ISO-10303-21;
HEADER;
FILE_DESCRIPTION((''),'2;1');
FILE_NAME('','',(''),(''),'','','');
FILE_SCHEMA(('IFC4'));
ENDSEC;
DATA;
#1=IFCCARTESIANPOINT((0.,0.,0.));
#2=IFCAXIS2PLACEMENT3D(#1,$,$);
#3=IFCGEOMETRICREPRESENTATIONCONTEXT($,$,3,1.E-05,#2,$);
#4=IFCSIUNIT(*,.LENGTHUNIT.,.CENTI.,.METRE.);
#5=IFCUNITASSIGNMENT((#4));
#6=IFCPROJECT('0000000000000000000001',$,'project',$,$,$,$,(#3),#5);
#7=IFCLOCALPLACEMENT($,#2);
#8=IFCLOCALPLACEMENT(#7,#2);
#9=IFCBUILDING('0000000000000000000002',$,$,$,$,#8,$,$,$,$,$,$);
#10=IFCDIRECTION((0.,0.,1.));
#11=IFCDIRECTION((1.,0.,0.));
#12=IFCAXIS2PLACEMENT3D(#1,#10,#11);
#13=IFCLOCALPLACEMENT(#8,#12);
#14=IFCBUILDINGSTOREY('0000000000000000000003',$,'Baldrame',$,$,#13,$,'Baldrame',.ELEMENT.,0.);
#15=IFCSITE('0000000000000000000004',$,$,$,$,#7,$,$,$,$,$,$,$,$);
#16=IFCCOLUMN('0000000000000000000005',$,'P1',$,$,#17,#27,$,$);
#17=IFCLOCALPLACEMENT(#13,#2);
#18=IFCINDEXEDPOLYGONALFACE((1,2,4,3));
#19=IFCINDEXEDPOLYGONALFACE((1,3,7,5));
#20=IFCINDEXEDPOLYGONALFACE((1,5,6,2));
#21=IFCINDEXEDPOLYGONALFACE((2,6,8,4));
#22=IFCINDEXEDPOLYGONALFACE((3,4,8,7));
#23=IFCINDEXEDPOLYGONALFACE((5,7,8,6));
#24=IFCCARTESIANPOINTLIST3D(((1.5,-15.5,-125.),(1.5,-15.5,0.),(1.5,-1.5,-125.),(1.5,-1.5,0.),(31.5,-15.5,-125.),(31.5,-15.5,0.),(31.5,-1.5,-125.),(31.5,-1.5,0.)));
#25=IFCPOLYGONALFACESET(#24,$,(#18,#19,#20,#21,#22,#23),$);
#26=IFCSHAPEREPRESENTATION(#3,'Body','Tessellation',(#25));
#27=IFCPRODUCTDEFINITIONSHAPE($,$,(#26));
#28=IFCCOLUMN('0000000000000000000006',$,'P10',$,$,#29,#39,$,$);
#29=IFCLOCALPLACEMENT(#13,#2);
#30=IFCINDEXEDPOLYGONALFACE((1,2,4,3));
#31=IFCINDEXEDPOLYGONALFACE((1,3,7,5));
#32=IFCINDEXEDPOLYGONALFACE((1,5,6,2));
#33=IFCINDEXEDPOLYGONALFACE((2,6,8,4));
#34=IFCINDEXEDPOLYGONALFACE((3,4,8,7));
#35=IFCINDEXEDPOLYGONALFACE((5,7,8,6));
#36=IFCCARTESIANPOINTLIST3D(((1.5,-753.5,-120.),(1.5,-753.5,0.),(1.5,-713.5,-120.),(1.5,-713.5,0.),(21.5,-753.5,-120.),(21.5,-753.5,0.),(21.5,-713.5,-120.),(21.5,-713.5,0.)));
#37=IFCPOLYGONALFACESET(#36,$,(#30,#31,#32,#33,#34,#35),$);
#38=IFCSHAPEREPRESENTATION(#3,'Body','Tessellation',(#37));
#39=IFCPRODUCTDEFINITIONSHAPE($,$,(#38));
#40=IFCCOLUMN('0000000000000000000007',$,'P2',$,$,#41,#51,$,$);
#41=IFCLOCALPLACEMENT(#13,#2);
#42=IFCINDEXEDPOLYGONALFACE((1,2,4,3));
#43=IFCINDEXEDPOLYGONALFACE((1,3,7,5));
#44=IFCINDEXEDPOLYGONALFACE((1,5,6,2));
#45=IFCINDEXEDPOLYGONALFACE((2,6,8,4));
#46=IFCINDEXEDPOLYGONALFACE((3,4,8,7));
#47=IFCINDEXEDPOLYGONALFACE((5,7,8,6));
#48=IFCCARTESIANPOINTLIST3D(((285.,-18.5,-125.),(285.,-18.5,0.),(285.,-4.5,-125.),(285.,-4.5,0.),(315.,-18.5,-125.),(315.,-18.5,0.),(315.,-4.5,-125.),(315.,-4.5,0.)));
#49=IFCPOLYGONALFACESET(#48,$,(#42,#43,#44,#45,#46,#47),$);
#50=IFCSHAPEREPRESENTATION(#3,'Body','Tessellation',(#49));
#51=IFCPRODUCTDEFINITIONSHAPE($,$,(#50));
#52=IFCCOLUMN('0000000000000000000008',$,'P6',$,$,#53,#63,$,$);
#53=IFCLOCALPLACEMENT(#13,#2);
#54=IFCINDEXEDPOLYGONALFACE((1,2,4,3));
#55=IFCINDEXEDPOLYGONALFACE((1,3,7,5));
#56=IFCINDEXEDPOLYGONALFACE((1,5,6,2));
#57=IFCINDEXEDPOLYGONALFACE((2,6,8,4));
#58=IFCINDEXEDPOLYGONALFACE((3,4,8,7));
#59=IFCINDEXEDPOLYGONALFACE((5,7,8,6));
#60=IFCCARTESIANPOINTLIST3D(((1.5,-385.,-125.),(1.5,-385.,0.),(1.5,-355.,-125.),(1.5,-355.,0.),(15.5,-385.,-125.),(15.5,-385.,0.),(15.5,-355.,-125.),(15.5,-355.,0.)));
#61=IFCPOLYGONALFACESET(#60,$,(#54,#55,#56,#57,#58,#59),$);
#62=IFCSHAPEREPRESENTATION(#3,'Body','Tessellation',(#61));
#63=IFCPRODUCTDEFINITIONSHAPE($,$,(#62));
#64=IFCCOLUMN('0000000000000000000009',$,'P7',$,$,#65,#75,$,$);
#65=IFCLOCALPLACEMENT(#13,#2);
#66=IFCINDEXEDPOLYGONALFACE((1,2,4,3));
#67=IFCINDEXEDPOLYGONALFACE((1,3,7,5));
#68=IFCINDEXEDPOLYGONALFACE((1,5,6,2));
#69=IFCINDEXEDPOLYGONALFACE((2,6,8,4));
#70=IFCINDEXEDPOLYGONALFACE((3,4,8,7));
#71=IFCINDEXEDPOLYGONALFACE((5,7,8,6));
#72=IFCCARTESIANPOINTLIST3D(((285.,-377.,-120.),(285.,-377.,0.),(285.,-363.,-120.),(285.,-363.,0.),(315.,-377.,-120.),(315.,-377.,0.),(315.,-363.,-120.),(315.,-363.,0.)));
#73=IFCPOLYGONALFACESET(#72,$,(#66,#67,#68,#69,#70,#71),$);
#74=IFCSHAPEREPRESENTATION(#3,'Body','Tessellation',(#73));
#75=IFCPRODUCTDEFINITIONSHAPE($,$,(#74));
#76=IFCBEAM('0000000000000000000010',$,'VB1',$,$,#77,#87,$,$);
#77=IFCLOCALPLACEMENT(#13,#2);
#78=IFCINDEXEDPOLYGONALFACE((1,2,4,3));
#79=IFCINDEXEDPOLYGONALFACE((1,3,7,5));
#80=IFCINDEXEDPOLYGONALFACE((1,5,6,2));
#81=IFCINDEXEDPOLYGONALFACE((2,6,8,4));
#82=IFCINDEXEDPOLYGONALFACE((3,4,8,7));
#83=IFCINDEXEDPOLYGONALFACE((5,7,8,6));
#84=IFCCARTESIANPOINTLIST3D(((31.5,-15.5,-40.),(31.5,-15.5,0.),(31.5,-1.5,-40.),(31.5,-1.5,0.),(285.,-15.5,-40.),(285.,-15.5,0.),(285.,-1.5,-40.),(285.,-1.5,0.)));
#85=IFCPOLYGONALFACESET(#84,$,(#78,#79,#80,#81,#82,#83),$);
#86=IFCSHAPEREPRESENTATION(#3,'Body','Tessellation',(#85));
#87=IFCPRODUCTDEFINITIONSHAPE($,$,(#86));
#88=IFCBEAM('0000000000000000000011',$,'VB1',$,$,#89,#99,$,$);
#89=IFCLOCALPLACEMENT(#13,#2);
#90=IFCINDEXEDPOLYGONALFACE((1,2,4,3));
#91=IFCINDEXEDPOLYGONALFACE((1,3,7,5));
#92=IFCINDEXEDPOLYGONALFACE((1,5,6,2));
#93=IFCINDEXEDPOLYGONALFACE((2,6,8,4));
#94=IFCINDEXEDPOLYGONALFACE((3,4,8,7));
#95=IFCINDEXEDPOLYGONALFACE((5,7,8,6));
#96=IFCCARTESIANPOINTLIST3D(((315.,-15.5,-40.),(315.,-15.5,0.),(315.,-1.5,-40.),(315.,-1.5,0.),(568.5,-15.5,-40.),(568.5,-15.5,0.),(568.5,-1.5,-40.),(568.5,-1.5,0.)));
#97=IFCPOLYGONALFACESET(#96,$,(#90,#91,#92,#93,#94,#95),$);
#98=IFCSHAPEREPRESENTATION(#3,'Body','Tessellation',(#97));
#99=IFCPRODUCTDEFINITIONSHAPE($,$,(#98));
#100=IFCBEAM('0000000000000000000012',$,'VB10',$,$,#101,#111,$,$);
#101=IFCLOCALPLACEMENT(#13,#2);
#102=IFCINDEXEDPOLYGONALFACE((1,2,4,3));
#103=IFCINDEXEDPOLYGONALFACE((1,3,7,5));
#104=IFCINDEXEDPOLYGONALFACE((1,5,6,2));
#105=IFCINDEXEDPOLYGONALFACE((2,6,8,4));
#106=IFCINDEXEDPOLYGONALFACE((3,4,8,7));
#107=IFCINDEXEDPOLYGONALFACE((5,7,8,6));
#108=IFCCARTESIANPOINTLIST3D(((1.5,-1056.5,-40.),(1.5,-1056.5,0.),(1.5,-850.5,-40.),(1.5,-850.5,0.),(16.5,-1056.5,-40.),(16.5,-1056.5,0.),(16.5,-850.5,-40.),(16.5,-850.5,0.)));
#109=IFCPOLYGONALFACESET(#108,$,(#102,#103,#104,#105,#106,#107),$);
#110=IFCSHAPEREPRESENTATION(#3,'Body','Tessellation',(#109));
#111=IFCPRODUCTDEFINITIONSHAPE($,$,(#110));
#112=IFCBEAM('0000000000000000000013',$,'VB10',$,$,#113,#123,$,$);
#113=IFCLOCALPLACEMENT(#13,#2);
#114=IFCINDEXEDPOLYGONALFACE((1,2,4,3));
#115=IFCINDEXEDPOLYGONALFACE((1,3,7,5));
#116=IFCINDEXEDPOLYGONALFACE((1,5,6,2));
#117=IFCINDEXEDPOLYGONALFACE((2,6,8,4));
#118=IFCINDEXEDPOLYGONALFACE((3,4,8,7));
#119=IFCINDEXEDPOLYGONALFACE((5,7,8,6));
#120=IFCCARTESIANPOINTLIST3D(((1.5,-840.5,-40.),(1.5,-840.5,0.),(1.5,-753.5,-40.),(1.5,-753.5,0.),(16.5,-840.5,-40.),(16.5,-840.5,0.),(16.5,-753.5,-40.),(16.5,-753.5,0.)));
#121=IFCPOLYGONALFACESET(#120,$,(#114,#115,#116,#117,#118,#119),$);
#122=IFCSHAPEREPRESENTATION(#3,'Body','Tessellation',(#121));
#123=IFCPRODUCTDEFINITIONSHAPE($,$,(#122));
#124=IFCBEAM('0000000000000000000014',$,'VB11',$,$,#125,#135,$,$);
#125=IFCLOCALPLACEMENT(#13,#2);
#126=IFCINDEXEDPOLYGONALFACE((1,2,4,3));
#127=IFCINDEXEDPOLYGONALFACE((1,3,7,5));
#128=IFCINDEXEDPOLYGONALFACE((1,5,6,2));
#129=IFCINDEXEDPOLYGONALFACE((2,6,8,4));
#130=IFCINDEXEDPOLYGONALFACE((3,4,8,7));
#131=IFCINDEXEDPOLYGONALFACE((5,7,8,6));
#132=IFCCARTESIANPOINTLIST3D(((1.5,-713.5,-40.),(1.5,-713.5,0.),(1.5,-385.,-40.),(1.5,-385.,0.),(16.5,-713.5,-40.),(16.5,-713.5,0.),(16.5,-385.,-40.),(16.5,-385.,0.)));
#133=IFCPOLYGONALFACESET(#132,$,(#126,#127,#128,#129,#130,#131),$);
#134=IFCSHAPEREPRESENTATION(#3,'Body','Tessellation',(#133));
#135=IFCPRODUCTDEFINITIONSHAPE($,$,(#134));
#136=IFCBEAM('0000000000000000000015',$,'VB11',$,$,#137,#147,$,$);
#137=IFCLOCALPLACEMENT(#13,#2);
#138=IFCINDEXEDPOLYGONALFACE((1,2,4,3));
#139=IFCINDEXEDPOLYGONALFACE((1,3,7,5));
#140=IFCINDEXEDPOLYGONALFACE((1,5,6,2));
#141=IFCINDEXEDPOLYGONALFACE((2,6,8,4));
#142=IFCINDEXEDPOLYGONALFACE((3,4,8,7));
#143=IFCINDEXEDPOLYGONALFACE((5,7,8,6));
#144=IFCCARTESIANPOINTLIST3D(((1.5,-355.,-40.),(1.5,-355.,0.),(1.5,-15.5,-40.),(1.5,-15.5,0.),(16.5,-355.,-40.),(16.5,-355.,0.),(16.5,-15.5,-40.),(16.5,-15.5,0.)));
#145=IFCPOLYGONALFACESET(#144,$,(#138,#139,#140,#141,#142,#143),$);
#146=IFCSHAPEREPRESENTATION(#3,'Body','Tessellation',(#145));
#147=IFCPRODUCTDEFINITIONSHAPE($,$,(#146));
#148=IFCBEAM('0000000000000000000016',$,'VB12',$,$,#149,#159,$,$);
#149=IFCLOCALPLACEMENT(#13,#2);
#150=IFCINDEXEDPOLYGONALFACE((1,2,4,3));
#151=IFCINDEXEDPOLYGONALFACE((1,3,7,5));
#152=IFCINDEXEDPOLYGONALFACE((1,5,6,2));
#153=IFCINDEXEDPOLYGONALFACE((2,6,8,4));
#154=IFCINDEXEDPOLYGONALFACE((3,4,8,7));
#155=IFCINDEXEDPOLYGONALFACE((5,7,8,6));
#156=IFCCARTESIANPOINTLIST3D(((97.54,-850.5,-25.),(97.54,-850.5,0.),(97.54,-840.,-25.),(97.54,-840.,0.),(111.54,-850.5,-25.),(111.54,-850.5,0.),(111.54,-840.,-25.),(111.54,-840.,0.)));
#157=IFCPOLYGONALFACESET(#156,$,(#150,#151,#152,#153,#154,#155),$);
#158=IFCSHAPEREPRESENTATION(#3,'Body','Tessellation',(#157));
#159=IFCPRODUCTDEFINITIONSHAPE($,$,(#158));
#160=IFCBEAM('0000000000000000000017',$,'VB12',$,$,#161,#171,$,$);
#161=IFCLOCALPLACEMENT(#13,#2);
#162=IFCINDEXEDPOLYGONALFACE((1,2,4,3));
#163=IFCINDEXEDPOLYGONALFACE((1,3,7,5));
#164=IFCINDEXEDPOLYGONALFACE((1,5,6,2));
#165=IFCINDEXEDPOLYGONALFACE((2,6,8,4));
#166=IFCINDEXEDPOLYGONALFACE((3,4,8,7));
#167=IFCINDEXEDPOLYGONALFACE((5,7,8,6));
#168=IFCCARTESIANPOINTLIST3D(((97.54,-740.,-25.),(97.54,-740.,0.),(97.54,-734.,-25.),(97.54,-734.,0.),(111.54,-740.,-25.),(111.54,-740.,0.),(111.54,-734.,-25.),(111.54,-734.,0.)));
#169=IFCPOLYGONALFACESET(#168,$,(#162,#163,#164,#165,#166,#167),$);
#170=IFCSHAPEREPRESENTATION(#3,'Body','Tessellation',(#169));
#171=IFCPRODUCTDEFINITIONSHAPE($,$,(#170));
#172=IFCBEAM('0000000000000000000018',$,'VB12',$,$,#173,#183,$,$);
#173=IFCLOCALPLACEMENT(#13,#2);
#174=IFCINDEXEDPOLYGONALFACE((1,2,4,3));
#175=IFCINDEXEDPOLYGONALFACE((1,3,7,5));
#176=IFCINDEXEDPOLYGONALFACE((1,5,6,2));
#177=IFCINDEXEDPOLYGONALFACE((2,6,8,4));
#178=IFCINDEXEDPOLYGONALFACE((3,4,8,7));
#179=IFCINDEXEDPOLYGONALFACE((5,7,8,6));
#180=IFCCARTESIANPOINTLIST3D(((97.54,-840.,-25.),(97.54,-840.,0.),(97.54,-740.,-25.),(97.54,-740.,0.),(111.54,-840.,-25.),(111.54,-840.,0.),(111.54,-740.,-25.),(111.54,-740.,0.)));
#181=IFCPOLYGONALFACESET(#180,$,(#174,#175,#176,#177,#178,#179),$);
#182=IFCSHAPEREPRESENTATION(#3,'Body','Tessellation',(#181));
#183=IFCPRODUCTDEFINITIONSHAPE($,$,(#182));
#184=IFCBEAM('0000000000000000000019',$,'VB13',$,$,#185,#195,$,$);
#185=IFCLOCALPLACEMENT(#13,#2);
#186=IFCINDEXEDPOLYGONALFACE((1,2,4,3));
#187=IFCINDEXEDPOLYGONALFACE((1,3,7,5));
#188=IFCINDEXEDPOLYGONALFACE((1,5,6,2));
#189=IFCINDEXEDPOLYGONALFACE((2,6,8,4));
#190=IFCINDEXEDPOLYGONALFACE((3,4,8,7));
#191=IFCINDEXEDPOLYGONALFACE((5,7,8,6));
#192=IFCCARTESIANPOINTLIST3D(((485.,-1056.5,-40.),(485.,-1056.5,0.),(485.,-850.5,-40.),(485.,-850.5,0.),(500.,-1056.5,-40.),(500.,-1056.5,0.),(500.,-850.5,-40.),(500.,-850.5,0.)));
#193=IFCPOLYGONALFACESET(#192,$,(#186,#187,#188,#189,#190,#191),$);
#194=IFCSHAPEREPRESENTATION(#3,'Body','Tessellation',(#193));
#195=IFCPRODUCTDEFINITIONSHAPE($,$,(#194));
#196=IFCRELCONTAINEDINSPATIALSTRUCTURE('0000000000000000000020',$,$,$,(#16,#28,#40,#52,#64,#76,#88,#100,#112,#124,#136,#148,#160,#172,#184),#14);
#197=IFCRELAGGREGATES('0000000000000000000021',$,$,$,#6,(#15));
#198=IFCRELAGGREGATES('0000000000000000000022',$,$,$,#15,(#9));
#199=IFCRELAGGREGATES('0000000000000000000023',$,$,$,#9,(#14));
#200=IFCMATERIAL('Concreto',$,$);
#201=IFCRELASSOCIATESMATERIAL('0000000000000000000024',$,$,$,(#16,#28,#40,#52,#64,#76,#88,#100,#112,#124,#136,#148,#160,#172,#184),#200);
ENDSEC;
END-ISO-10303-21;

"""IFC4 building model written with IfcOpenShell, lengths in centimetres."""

from ifc_helpers import new_model, si_unit, frame, origin, origin_with_axes, place, context, project, spatial, polyline, outline, extrude, material, element, save


model = new_model("IFC4")

# Units and contexts
context_of_model = context(None, 3, precision=1e-05, world=origin())
ifc_project = project(units=[si_unit("LENGTHUNIT", "METRE", prefix="CENTI")], contexts=[context_of_model])

# Site, building, storey
site_placement = place(None, origin())
site = spatial("IfcSite", under=ifc_project, at=site_placement)
building_placement = place(site_placement, origin())
building = spatial("IfcBuilding", under=site, at=building_placement)
storey_placement = place(building_placement, origin_with_axes())
storey = spatial("IfcBuildingStorey", under=building, at=storey_placement, Name="Baldrame", LongName="Baldrame", CompositionType="ELEMENT", Elevation=0.0)

# Columns
ifc_material = material(Name="Concreto")
column_1_placement = place(storey_placement, frame((16.5, -8.5, 0.0), z_axis=(0.0, 0.0, 1.0), x_axis=(1.0, 0.0, 0.0)))
element("IfcColumn", 1, at=column_1_placement, inside=storey, material=ifc_material, Name="P1", context=context_of_model, shape_type="SolidModel", body=[
    extrude(outline(polyline([(-15.0, 7.0), (-15.0, -7.0), (15.0, -7.0), (15.0, 7.0), (-15.0, 7.0)])), frame((0.0, 0.0, -125.0), z_axis=(0.0, 0.0, 1.0), x_axis=(1.0, 0.0, 0.0)), (0.0, 0.0, 1.0), 125.0),
])
column_2_placement = place(storey_placement, frame((11.5, -733.5, 0.0), z_axis=(0.0, 0.0, 1.0), x_axis=(1.0, 0.0, 0.0)))
element("IfcColumn", 2, at=column_2_placement, inside=storey, material=ifc_material, Name="P10", context=context_of_model, shape_type="SolidModel", body=[
    extrude(outline(polyline([(10.0, 20.0), (-10.0, 20.0), (-10.0, -20.0), (10.0, -20.0), (10.0, 20.0)])), frame((0.0, 0.0, -120.0), z_axis=(0.0, 0.0, 1.0), x_axis=(1.0, 0.0, 0.0)), (0.0, 0.0, 1.0), 120.0),
])
column_3_placement = place(storey_placement, frame((300.0, -11.5, 0.0), z_axis=(0.0, 0.0, 1.0), x_axis=(1.0, 0.0, 0.0)))
element("IfcColumn", 3, at=column_3_placement, inside=storey, material=ifc_material, Name="P2", context=context_of_model, shape_type="SolidModel", body=[
    extrude(outline(polyline([(15.0, -7.0), (15.0, 7.0), (-15.0, 7.0), (-15.0, -7.0), (15.0, -7.0)])), frame((0.0, 0.0, -125.0), z_axis=(0.0, 0.0, 1.0), x_axis=(1.0, 0.0, 0.0)), (0.0, 0.0, 1.0), 125.0),
])
column_4_placement = place(storey_placement, frame((8.5, -370.0, 0.0), z_axis=(0.0, 0.0, 1.0), x_axis=(1.0, 0.0, 0.0)))
element("IfcColumn", 4, at=column_4_placement, inside=storey, material=ifc_material, Name="P6", context=context_of_model, shape_type="SolidModel", body=[
    extrude(outline(polyline([(-7.0, -15.0), (7.0, -15.0), (7.0, 15.0), (-7.0, 15.0), (-7.0, -15.0)])), frame((0.0, 0.0, -125.0), z_axis=(0.0, 0.0, 1.0), x_axis=(1.0, 0.0, 0.0)), (0.0, 0.0, 1.0), 125.0),
])
column_5_placement = place(storey_placement, frame((300.0, -370.0, 0.0), z_axis=(0.0, 0.0, 1.0), x_axis=(1.0, 0.0, 0.0)))
element("IfcColumn", 5, at=column_5_placement, inside=storey, material=ifc_material, Name="P7", context=context_of_model, shape_type="SolidModel", body=[
    extrude(outline(polyline([(15.0, -7.0), (15.0, 7.0), (-15.0, 7.0), (-15.0, -7.0), (15.0, -7.0)])), frame((0.0, 0.0, -120.0), z_axis=(0.0, 0.0, 1.0), x_axis=(1.0, 0.0, 0.0)), (0.0, 0.0, 1.0), 120.0),
])

# Beams
for number, where, z_axis, x_axis, name in (
    (6, (158.25, -8.5, 0.0), (0.0, 0.0, 1.0), (1.0, 0.0, 0.0), "VB1"),
    (7, (441.75, -8.5, 0.0), (0.0, 0.0, 1.0), (1.0, 0.0, 0.0), "VB1"),
):
    element("IfcBeam", number, at=place(storey_placement, frame(where, z_axis=z_axis, x_axis=x_axis)), inside=storey, material=ifc_material, Name=name, context=context_of_model, shape_type="SolidModel", body=[
        extrude(outline(polyline([(7.0, 20.0), (-7.0, 20.0), (-7.0, -20.0), (7.0, -20.0), (7.0, 20.0)])), frame((-126.75, 0.0, -20.0), z_axis=(1.0, 0.0, 0.0), x_axis=(0.0, 1.0, 0.0)), (0.0, 0.0, 1.0), 253.5),
    ])
beam_1_placement = place(storey_placement, frame((9.0, -953.5, 0.0), z_axis=(0.0, 0.0, 1.0), x_axis=(1.0, 0.0, 0.0)))
element("IfcBeam", 8, at=beam_1_placement, inside=storey, material=ifc_material, Name="VB10", context=context_of_model, shape_type="SolidModel", body=[
    extrude(outline(polyline([(-7.5, -20.0), (7.5, -20.0), (7.5, 20.0), (-7.5, 20.0), (-7.5, -20.0)])), frame((0.0, -103.0, -20.0), z_axis=(0.0, 1.0, 0.0), x_axis=(1.0, 0.0, 0.0)), (0.0, 0.0, 1.0), 206.0),
])
beam_2_placement = place(storey_placement, frame((9.0, -797.0, 0.0), z_axis=(0.0, 0.0, 1.0), x_axis=(1.0, 0.0, 0.0)))
element("IfcBeam", 9, at=beam_2_placement, inside=storey, material=ifc_material, Name="VB10", context=context_of_model, shape_type="SolidModel", body=[
    extrude(outline(polyline([(-7.5, -20.0), (7.5, -20.0), (7.5, 20.0), (-7.5, 20.0), (-7.5, -20.0)])), frame((0.0, -43.5, -20.0), z_axis=(0.0, 1.0, 0.0), x_axis=(1.0, 0.0, 0.0)), (0.0, 0.0, 1.0), 87.0),
])
beam_3_placement = place(storey_placement, frame((9.0, -549.25, 0.0), z_axis=(0.0, 0.0, 1.0), x_axis=(1.0, 0.0, 0.0)))
element("IfcBeam", 10, at=beam_3_placement, inside=storey, material=ifc_material, Name="VB11", context=context_of_model, shape_type="SolidModel", body=[
    extrude(outline(polyline([(-7.5, -20.0), (7.5, -20.0), (7.5, 20.0), (-7.5, 20.0), (-7.5, -20.0)])), frame((0.0, -164.25, -20.0), z_axis=(0.0, 1.0, 0.0), x_axis=(1.0, 0.0, 0.0)), (0.0, 0.0, 1.0), 328.5),
])
beam_4_placement = place(storey_placement, frame((9.0, -185.25, 0.0), z_axis=(0.0, 0.0, 1.0), x_axis=(1.0, 0.0, 0.0)))
element("IfcBeam", 11, at=beam_4_placement, inside=storey, material=ifc_material, Name="VB11", context=context_of_model, shape_type="SolidModel", body=[
    extrude(outline(polyline([(-7.5, -20.0), (7.5, -20.0), (7.5, 20.0), (-7.5, 20.0), (-7.5, -20.0)])), frame((0.0, -169.75, -20.0), z_axis=(0.0, 1.0, 0.0), x_axis=(1.0, 0.0, 0.0)), (0.0, 0.0, 1.0), 339.5),
])
beam_5_placement = place(storey_placement, frame((104.54, -845.25, 0.0), z_axis=(0.0, 0.0, 1.0), x_axis=(1.0, 0.0, 0.0)))
element("IfcBeam", 12, at=beam_5_placement, inside=storey, material=ifc_material, Name="VB12", context=context_of_model, shape_type="SolidModel", body=[
    extrude(outline(polyline([(-7.0, -12.5), (7.0, -12.5), (7.0, 12.5), (-7.0, 12.5), (-7.0, -12.5)])), frame((0.0, -5.25, -12.5), z_axis=(0.0, 1.0, 0.0), x_axis=(1.0, 0.0, 0.0)), (0.0, 0.0, 1.0), 10.5),
])
beam_6_placement = place(storey_placement, frame((104.54, -737.0, 0.0), z_axis=(0.0, 0.0, 1.0), x_axis=(1.0, 0.0, 0.0)))
element("IfcBeam", 13, at=beam_6_placement, inside=storey, material=ifc_material, Name="VB12", context=context_of_model, shape_type="SolidModel", body=[
    extrude(outline(polyline([(-7.0, -12.5), (7.0, -12.5), (7.0, 12.5), (-7.0, 12.5), (-7.0, -12.5)])), frame((0.0, -3.0, -12.5), z_axis=(0.0, 1.0, 0.0), x_axis=(1.0, 0.0, 0.0)), (0.0, 0.0, 1.0), 6.0),
])
beam_7_placement = place(storey_placement, frame((104.54, -790.0, 0.0), z_axis=(0.0, 0.0, 1.0), x_axis=(1.0, 0.0, 0.0)))
element("IfcBeam", 14, at=beam_7_placement, inside=storey, material=ifc_material, Name="VB12", context=context_of_model, shape_type="SolidModel", body=[
    extrude(outline(polyline([(-7.0, -12.5), (7.0, -12.5), (7.0, 12.5), (-7.0, 12.5), (-7.0, -12.5)])), frame((0.0, -50.0, -12.5), z_axis=(0.0, 1.0, 0.0), x_axis=(1.0, 0.0, 0.0)), (0.0, 0.0, 1.0), 100.0),
])
beam_8_placement = place(storey_placement, frame((492.5, -953.5, 0.0), z_axis=(0.0, 0.0, 1.0), x_axis=(1.0, 0.0, 0.0)))
element("IfcBeam", 15, at=beam_8_placement, inside=storey, material=ifc_material, Name="VB13", context=context_of_model, shape_type="SolidModel", body=[
    extrude(outline(polyline([(-7.5, -20.0), (7.5, -20.0), (7.5, 20.0), (-7.5, 20.0), (-7.5, -20.0)])), frame((0.0, -103.0, -20.0), z_axis=(0.0, 1.0, 0.0), x_axis=(1.0, 0.0, 0.0)), (0.0, 0.0, 1.0), 206.0),
])

save(model, "model.ifc")
